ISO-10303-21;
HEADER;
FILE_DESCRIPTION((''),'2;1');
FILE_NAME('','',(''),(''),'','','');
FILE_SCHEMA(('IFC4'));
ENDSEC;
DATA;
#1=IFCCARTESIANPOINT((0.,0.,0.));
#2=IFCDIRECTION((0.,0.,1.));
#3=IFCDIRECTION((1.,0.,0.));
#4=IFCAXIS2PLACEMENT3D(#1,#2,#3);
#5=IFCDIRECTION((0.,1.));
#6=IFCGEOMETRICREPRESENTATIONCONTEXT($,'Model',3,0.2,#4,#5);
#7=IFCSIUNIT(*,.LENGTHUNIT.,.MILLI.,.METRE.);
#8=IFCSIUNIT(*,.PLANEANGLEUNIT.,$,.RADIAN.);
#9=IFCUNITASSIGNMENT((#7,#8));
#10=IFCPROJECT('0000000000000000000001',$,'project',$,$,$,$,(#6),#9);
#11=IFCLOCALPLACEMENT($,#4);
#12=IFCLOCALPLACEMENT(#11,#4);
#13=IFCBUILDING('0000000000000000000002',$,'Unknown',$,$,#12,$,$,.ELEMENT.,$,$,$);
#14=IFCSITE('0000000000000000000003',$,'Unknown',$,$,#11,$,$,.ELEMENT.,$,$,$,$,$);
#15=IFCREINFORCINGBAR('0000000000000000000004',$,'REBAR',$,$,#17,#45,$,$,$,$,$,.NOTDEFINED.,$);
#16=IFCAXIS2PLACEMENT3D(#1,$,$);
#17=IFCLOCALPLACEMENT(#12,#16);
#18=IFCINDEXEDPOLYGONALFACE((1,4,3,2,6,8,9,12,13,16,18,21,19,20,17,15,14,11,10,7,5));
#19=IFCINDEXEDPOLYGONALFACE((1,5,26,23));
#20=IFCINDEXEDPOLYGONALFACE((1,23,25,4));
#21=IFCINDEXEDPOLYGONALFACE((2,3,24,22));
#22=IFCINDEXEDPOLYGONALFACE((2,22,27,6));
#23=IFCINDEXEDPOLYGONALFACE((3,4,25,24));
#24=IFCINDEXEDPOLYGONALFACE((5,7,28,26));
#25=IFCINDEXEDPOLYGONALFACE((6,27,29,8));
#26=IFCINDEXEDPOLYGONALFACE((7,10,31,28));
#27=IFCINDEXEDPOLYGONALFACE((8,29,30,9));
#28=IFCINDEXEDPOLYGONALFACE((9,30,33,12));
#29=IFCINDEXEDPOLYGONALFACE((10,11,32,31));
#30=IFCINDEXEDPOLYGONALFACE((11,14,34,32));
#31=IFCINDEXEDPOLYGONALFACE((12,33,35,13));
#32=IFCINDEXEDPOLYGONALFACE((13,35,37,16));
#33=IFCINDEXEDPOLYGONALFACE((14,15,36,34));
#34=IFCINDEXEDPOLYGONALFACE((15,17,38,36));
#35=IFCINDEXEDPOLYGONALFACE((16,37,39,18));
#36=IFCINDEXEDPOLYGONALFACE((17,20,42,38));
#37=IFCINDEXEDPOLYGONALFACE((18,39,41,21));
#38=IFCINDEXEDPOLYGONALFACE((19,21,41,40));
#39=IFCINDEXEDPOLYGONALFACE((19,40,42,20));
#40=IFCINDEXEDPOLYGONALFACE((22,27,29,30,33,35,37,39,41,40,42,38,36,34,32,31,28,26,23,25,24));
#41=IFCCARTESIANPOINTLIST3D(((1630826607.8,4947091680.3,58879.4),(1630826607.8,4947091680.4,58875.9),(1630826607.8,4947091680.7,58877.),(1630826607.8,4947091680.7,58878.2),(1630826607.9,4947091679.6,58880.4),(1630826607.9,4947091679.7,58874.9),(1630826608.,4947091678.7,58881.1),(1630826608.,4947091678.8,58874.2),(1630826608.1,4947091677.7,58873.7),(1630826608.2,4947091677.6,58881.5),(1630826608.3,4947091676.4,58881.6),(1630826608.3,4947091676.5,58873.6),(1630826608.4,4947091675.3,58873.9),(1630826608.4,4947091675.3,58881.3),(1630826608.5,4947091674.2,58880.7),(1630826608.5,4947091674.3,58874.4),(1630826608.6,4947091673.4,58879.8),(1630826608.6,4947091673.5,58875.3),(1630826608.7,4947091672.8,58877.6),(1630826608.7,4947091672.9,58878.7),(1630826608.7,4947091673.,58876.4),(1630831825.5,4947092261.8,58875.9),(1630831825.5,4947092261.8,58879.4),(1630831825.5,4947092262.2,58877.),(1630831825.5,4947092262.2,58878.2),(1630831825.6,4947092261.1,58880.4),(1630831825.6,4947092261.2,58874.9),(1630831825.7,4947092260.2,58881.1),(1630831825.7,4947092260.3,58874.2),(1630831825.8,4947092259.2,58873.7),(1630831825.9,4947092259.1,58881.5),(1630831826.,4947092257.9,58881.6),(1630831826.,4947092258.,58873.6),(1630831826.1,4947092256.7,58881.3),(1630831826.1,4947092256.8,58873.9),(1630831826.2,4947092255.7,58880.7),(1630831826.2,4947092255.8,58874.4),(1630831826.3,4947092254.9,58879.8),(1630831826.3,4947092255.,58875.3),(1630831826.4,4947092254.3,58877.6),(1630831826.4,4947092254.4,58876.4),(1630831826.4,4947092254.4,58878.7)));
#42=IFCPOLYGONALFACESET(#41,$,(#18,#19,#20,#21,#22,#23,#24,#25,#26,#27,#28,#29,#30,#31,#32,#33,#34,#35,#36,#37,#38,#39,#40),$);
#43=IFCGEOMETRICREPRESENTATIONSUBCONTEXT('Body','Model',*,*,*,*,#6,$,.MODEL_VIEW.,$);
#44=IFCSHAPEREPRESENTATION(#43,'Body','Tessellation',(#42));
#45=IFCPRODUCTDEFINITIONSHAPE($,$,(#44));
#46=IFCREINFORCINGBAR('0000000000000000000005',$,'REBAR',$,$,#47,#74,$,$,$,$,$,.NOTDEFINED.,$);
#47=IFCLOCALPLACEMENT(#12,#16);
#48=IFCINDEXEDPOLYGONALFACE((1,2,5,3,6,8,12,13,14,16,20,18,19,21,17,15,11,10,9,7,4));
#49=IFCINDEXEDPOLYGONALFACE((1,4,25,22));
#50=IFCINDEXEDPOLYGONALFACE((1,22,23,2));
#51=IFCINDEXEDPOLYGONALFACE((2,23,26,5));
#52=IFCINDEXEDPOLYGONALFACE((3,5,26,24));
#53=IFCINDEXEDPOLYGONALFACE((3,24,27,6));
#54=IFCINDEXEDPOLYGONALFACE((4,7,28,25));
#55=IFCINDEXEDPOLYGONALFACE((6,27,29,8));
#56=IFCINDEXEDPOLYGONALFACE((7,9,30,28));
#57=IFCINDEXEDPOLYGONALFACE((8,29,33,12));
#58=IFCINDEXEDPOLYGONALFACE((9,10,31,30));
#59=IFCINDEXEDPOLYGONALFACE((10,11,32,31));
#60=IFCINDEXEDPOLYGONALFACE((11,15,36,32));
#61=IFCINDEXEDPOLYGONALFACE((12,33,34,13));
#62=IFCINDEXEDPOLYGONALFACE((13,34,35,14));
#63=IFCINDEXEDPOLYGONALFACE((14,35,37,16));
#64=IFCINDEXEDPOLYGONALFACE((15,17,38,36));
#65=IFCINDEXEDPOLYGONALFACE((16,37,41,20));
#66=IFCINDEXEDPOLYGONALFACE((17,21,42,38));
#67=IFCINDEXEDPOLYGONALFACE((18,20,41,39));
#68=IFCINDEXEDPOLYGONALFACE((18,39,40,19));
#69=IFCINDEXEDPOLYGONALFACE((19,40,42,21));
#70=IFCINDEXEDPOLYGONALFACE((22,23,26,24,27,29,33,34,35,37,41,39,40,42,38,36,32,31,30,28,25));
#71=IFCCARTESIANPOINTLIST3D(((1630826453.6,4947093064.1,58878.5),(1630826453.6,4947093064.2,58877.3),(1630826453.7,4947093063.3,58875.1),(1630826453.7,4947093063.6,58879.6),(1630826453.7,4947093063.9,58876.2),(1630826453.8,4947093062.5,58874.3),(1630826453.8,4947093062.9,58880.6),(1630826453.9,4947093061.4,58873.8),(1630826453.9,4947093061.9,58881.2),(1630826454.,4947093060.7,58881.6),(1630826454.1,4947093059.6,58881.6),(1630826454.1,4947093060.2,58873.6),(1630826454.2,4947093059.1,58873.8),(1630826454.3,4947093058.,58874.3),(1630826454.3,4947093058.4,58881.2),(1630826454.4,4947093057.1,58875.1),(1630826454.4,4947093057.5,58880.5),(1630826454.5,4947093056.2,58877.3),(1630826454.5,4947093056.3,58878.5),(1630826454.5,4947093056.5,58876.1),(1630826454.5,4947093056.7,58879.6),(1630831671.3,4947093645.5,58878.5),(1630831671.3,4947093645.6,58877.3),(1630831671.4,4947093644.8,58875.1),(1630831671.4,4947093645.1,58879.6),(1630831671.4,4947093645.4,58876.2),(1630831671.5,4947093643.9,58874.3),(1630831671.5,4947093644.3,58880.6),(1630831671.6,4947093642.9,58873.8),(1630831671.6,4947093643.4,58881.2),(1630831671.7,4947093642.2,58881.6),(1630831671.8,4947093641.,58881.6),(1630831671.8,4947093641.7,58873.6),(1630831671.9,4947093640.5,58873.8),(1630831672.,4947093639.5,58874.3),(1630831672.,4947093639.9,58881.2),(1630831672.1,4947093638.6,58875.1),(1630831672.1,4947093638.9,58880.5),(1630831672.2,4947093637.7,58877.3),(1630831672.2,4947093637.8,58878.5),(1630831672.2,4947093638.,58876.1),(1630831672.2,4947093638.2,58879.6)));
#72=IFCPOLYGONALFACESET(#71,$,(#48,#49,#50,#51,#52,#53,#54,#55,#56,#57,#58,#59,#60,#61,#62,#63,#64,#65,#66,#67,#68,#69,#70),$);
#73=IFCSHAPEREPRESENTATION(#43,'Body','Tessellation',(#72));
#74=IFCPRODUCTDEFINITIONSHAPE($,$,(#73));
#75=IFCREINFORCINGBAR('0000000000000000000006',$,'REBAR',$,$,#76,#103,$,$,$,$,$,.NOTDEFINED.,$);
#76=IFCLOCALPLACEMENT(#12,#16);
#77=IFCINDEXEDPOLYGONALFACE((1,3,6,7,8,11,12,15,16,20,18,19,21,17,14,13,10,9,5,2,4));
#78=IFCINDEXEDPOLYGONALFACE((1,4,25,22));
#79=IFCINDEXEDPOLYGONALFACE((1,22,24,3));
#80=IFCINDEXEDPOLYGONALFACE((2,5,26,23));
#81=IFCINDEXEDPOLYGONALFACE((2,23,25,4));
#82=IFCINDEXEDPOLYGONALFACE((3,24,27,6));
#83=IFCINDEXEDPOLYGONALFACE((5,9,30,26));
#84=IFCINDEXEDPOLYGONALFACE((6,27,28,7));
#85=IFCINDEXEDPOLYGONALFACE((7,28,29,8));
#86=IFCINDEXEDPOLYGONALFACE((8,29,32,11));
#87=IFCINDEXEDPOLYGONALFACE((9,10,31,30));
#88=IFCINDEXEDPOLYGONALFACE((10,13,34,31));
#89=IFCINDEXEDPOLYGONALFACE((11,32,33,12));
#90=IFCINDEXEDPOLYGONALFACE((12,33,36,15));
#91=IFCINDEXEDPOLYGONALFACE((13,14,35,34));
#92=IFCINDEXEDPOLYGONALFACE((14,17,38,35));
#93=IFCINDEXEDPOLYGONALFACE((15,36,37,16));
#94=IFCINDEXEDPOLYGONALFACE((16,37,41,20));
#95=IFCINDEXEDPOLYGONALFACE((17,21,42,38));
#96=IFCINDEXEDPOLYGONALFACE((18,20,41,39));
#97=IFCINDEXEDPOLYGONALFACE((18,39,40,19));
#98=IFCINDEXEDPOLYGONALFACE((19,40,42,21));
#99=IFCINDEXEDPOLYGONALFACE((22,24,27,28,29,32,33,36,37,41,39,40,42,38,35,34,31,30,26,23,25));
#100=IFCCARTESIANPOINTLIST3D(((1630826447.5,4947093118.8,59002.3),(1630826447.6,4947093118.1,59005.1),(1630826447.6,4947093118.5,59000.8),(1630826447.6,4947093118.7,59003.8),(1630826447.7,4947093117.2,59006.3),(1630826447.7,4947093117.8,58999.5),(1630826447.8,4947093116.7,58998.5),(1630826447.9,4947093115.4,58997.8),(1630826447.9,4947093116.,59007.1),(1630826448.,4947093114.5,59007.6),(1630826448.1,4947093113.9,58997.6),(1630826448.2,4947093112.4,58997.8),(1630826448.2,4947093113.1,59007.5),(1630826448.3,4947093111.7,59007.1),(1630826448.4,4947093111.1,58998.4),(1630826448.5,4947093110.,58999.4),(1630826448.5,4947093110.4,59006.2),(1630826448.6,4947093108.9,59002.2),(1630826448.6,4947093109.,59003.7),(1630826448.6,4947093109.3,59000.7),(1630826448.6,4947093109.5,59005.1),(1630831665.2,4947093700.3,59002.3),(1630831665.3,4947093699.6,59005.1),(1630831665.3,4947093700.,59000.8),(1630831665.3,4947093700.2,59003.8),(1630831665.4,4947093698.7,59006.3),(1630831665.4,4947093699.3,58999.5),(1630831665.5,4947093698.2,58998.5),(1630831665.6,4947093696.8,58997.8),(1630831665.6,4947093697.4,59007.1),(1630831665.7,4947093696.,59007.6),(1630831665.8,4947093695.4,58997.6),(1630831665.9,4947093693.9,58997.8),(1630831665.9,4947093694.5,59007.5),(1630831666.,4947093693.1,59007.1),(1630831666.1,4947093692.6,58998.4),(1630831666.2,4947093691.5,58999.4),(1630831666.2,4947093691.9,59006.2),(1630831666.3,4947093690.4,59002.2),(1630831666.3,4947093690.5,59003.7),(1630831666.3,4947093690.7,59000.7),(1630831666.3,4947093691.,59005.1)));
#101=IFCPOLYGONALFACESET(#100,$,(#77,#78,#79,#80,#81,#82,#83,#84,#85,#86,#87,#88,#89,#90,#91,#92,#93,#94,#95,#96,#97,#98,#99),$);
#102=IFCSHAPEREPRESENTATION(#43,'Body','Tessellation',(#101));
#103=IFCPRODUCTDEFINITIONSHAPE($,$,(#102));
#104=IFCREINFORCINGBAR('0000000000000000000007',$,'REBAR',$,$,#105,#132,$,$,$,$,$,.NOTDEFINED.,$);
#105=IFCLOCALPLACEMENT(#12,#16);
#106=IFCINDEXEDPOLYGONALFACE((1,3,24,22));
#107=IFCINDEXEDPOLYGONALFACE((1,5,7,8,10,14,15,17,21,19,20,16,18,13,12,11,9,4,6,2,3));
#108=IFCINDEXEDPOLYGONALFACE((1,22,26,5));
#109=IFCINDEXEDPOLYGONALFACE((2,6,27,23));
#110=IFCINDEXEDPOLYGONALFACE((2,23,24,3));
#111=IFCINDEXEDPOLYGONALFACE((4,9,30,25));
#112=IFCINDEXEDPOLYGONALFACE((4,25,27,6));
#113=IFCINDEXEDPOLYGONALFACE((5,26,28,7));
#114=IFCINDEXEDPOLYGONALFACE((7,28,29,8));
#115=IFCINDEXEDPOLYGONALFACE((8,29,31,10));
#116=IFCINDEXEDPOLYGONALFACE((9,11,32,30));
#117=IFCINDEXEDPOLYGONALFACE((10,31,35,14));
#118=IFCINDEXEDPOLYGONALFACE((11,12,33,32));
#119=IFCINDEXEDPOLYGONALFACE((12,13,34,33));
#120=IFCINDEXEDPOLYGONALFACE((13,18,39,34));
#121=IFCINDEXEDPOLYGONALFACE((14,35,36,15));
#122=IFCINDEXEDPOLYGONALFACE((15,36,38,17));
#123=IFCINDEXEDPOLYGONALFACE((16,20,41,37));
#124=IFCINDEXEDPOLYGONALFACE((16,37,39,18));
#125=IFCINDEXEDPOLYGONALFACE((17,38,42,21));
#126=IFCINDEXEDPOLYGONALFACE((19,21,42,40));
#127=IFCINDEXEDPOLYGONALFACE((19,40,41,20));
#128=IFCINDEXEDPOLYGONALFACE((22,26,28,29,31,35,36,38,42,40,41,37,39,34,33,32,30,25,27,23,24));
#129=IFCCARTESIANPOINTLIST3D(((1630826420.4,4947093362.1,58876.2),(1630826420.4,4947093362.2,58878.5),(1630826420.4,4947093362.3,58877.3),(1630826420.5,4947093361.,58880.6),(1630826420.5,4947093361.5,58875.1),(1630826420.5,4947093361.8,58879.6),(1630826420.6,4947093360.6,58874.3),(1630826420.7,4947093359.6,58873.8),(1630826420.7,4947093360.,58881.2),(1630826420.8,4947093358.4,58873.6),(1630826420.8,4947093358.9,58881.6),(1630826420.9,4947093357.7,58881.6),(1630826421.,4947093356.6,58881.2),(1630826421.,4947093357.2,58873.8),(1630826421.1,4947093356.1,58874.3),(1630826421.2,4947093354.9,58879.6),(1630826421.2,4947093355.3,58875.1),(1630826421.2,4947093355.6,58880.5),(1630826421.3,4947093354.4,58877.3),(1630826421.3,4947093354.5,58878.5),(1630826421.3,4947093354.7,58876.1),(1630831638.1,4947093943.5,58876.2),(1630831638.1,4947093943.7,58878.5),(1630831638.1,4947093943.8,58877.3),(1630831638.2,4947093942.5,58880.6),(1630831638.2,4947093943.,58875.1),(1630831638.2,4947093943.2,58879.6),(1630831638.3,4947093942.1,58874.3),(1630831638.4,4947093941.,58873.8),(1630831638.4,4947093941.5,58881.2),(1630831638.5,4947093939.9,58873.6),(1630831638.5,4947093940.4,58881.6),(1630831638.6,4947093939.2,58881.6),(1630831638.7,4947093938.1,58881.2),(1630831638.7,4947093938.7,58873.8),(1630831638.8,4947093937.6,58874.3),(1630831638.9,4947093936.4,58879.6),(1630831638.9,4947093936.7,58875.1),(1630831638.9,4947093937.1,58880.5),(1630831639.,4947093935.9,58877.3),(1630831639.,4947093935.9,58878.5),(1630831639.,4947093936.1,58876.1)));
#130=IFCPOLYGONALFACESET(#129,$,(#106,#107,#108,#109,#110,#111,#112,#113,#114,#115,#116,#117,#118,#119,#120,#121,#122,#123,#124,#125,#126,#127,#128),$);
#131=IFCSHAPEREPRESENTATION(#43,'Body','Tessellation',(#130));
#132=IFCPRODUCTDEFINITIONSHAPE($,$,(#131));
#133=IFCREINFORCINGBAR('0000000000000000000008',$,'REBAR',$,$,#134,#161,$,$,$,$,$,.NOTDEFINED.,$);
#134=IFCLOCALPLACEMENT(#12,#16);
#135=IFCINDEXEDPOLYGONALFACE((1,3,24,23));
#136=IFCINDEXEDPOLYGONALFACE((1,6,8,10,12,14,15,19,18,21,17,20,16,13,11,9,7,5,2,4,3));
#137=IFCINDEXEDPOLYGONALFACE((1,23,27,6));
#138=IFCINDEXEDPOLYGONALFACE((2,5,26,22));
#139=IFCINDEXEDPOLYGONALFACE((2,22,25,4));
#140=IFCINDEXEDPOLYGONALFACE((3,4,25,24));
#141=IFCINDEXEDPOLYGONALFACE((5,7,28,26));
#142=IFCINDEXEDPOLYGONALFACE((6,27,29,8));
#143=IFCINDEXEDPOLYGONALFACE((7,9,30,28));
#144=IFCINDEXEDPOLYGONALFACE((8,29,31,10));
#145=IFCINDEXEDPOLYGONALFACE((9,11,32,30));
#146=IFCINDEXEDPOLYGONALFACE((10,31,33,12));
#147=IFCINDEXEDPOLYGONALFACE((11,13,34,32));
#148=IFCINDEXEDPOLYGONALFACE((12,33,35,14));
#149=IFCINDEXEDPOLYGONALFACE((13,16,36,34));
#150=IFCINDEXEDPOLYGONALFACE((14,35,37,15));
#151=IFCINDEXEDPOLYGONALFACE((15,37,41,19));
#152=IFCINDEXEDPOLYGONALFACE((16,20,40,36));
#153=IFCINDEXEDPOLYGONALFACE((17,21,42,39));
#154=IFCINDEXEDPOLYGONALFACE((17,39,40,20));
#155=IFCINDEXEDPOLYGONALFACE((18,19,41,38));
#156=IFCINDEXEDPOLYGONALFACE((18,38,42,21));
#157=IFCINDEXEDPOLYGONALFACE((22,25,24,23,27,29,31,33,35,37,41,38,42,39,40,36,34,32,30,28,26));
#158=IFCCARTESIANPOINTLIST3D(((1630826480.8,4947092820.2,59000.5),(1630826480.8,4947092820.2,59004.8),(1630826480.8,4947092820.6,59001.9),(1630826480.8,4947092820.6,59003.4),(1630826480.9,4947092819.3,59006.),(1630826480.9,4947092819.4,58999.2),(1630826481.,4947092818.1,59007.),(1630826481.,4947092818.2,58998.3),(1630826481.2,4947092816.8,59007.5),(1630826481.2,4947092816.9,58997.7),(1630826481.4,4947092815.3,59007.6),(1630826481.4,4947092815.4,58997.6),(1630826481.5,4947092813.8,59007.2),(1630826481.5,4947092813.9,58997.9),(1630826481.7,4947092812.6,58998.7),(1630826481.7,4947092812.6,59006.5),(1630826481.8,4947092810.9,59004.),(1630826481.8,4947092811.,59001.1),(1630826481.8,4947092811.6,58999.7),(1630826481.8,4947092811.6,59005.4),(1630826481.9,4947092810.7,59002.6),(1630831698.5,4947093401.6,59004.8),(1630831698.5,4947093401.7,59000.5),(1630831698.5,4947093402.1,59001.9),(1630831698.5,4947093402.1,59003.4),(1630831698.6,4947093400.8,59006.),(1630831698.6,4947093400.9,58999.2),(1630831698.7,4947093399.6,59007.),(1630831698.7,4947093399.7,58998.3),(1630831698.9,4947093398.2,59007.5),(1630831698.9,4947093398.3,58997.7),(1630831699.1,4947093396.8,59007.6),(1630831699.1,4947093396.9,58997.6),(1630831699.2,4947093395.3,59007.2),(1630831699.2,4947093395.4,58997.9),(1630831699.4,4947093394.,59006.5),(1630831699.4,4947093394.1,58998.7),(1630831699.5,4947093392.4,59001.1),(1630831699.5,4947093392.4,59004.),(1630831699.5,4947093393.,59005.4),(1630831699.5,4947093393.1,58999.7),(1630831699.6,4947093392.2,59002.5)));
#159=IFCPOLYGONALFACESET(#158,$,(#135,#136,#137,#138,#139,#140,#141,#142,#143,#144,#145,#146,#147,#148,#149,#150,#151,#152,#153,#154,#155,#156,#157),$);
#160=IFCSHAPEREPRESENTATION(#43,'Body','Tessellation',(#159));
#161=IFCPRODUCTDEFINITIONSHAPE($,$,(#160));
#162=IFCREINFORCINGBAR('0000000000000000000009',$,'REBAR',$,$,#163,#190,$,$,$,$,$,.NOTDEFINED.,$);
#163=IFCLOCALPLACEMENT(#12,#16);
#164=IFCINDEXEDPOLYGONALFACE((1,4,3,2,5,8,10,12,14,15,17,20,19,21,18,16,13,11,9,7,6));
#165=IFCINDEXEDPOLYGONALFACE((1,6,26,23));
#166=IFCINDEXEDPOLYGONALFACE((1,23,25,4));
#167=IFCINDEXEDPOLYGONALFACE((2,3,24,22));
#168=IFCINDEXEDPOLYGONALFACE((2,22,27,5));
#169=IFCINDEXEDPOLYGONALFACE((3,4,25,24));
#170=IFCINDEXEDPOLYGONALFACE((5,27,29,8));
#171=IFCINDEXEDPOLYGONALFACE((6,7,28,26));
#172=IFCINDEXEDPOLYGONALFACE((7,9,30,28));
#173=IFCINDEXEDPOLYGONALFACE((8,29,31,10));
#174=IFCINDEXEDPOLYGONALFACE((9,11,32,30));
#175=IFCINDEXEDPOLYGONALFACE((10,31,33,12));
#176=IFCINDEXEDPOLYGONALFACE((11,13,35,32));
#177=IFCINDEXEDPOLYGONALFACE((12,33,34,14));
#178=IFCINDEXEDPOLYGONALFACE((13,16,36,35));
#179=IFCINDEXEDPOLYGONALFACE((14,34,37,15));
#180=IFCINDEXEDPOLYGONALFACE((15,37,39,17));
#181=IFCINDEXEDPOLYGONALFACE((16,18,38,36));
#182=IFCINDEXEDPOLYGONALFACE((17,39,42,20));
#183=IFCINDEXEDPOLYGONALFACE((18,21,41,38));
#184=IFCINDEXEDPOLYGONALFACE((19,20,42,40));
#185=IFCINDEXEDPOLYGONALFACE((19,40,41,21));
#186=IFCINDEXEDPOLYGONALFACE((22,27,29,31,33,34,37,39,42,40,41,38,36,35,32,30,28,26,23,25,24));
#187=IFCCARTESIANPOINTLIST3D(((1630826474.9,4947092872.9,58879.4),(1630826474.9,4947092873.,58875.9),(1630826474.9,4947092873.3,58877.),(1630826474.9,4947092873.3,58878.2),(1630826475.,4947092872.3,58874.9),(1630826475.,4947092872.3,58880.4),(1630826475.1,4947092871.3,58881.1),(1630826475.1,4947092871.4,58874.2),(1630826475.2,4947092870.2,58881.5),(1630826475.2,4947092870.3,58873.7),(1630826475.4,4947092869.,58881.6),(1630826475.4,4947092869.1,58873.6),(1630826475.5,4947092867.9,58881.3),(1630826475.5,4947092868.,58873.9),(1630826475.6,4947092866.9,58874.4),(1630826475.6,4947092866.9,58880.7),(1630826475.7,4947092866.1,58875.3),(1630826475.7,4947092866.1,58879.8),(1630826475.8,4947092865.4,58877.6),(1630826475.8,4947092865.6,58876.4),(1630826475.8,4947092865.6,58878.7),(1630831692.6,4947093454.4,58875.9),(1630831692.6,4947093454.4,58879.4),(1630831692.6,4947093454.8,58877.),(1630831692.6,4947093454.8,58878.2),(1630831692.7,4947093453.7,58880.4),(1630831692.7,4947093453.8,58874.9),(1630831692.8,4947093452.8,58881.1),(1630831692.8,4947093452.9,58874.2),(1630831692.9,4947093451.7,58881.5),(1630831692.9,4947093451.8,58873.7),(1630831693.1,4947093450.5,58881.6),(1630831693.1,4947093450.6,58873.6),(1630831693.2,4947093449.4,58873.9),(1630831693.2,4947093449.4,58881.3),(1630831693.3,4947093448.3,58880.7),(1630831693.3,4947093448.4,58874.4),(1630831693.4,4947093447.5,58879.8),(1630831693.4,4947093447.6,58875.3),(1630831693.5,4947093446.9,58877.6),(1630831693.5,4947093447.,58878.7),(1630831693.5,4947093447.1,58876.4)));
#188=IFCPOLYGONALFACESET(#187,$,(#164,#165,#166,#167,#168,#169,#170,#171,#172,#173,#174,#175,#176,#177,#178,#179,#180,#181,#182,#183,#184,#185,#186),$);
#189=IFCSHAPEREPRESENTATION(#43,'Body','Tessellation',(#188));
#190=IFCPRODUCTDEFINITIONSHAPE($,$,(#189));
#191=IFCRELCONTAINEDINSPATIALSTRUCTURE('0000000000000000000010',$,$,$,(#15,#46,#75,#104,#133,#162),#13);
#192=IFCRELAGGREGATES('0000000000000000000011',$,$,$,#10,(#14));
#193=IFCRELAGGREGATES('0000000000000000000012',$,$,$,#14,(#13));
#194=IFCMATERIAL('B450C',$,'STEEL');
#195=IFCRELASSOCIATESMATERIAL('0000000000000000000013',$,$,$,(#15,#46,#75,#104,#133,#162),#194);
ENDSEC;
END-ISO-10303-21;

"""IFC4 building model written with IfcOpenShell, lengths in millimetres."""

from ifc_helpers import new_model, entity, si_unit, direction, frame, origin_with_axes, place, context, subcontext, project, spatial, material, element, save


model = new_model("IFC4")

# Units and contexts
model_context = context("Model", 3, precision=0.2, world=origin_with_axes(), true_north=direction((0.0, 1.0)))
body_context = subcontext(model_context, "Body", "Model", "MODEL_VIEW")
ifc_project = project(units=[si_unit("LENGTHUNIT", "METRE", prefix="MILLI"), si_unit("PLANEANGLEUNIT", "RADIAN")], contexts=[model_context])

# Site, building
site_placement = place(None, origin_with_axes())
site = spatial("IfcSite", under=ifc_project, at=site_placement, Name="Unknown", CompositionType="ELEMENT")
building_placement = place(site_placement, origin_with_axes())
building = spatial("IfcBuilding", under=site, at=building_placement, Name="Unknown", CompositionType="ELEMENT")

# Reinforcing bars
ifc_material = material(Name="B450C", Category="STEEL")
reinforcing_bar_1_placement = place(building_placement, frame((1630831825.9, 4947092258.2, 58877.6), z_axis=(0.007106, -0.063762, -0.99794), x_axis=(-0.993847, -0.110757, 0.0)))
element("IfcReinforcingBar", 1, at=reinforcing_bar_1_placement, inside=building, material=ifc_material, Name="REBAR", PredefinedType="NOTDEFINED", context=body_context, shape_type="AdvancedSweptSolid", body=[
    entity("IfcSweptDiskSolid", entity("IfcIndexedPolyCurve", entity("IfcCartesianPointList3D", [[0.0, 0.0, 0.0], [5250.0, 0.0, 0.0]]), [entity("IfcLineIndex", [1, 2])]), 4.0),
])
reinforcing_bar_2_placement = place(building_placement, frame((1630831671.8, 4947093641.7, 58877.6), z_axis=(0.007106, -0.063762, -0.99794), x_axis=(-0.993847, -0.110757, 0.0)))
element("IfcReinforcingBar", 2, at=reinforcing_bar_2_placement, inside=building, material=ifc_material, Name="REBAR", PredefinedType="NOTDEFINED", context=body_context, shape_type="AdvancedSweptSolid", body=[
    entity("IfcSweptDiskSolid", entity("IfcIndexedPolyCurve", entity("IfcCartesianPointList3D", [[0.0, 0.0, 0.0], [5250.0, 0.0, 0.0]]), [entity("IfcLineIndex", [1, 2])]), 4.0),
])
reinforcing_bar_3_placement = place(building_placement, frame((1630831665.8, 4947093695.3, 59002.6), z_axis=(0.007106, -0.063762, -0.99794), x_axis=(-0.993847, -0.110757, 0.0)))
element("IfcReinforcingBar", 3, at=reinforcing_bar_3_placement, inside=building, material=ifc_material, Name="REBAR", PredefinedType="NOTDEFINED", context=body_context, shape_type="AdvancedSweptSolid", body=[
    entity("IfcSweptDiskSolid", entity("IfcIndexedPolyCurve", entity("IfcCartesianPointList3D", [[0.0, 0.0, 0.0], [5250.0, 0.0, 0.0]]), [entity("IfcLineIndex", [1, 2])]), 5.0),
])
for number, where, z_axis, x_axis, name in (
    (4, (1630831638.5, 4947093939.8, 58877.6), (0.007106, -0.063762, -0.99794), (-0.993847, -0.110757, 0.0), "REBAR"),
):
    element("IfcReinforcingBar", number, at=place(building_placement, frame(where, z_axis=z_axis, x_axis=x_axis)), inside=building, material=ifc_material, Name=name, PredefinedType="NOTDEFINED", context=body_context, shape_type="AdvancedSweptSolid", body=[
        entity("IfcSweptDiskSolid", entity("IfcIndexedPolyCurve", entity("IfcCartesianPointList3D", [[0.0, 0.0, 0.0], [5250.0, 0.0, 0.0]]), [entity("IfcLineIndex", [1, 2])]), 4.0),
    ])
reinforcing_bar_4_placement = place(building_placement, frame((1630831699.0, 4947093397.2, 59002.6), z_axis=(0.007106, -0.063762, -0.99794), x_axis=(-0.993847, -0.110757, 0.0)))
element("IfcReinforcingBar", 5, at=reinforcing_bar_4_placement, inside=building, material=ifc_material, Name="REBAR", PredefinedType="NOTDEFINED", context=body_context, shape_type="AdvancedSweptSolid", body=[
    entity("IfcSweptDiskSolid", entity("IfcIndexedPolyCurve", entity("IfcCartesianPointList3D", [[0.0, 0.0, 0.0], [5250.0, 0.0, 0.0]]), [entity("IfcLineIndex", [1, 2])]), 5.0),
])
reinforcing_bar_5_placement = place(building_placement, frame((1630831693.0, 4947093450.8, 58877.6), z_axis=(0.007106, -0.063762, -0.99794), x_axis=(-0.993847, -0.110757, 0.0)))
element("IfcReinforcingBar", 6, at=reinforcing_bar_5_placement, inside=building, material=ifc_material, Name="REBAR", PredefinedType="NOTDEFINED", context=body_context, shape_type="AdvancedSweptSolid", body=[
    entity("IfcSweptDiskSolid", entity("IfcIndexedPolyCurve", entity("IfcCartesianPointList3D", [[0.0, 0.0, 0.0], [5250.0, 0.0, 0.0]]), [entity("IfcLineIndex", [1, 2])]), 4.0),
])

save(model, "model.ifc")
